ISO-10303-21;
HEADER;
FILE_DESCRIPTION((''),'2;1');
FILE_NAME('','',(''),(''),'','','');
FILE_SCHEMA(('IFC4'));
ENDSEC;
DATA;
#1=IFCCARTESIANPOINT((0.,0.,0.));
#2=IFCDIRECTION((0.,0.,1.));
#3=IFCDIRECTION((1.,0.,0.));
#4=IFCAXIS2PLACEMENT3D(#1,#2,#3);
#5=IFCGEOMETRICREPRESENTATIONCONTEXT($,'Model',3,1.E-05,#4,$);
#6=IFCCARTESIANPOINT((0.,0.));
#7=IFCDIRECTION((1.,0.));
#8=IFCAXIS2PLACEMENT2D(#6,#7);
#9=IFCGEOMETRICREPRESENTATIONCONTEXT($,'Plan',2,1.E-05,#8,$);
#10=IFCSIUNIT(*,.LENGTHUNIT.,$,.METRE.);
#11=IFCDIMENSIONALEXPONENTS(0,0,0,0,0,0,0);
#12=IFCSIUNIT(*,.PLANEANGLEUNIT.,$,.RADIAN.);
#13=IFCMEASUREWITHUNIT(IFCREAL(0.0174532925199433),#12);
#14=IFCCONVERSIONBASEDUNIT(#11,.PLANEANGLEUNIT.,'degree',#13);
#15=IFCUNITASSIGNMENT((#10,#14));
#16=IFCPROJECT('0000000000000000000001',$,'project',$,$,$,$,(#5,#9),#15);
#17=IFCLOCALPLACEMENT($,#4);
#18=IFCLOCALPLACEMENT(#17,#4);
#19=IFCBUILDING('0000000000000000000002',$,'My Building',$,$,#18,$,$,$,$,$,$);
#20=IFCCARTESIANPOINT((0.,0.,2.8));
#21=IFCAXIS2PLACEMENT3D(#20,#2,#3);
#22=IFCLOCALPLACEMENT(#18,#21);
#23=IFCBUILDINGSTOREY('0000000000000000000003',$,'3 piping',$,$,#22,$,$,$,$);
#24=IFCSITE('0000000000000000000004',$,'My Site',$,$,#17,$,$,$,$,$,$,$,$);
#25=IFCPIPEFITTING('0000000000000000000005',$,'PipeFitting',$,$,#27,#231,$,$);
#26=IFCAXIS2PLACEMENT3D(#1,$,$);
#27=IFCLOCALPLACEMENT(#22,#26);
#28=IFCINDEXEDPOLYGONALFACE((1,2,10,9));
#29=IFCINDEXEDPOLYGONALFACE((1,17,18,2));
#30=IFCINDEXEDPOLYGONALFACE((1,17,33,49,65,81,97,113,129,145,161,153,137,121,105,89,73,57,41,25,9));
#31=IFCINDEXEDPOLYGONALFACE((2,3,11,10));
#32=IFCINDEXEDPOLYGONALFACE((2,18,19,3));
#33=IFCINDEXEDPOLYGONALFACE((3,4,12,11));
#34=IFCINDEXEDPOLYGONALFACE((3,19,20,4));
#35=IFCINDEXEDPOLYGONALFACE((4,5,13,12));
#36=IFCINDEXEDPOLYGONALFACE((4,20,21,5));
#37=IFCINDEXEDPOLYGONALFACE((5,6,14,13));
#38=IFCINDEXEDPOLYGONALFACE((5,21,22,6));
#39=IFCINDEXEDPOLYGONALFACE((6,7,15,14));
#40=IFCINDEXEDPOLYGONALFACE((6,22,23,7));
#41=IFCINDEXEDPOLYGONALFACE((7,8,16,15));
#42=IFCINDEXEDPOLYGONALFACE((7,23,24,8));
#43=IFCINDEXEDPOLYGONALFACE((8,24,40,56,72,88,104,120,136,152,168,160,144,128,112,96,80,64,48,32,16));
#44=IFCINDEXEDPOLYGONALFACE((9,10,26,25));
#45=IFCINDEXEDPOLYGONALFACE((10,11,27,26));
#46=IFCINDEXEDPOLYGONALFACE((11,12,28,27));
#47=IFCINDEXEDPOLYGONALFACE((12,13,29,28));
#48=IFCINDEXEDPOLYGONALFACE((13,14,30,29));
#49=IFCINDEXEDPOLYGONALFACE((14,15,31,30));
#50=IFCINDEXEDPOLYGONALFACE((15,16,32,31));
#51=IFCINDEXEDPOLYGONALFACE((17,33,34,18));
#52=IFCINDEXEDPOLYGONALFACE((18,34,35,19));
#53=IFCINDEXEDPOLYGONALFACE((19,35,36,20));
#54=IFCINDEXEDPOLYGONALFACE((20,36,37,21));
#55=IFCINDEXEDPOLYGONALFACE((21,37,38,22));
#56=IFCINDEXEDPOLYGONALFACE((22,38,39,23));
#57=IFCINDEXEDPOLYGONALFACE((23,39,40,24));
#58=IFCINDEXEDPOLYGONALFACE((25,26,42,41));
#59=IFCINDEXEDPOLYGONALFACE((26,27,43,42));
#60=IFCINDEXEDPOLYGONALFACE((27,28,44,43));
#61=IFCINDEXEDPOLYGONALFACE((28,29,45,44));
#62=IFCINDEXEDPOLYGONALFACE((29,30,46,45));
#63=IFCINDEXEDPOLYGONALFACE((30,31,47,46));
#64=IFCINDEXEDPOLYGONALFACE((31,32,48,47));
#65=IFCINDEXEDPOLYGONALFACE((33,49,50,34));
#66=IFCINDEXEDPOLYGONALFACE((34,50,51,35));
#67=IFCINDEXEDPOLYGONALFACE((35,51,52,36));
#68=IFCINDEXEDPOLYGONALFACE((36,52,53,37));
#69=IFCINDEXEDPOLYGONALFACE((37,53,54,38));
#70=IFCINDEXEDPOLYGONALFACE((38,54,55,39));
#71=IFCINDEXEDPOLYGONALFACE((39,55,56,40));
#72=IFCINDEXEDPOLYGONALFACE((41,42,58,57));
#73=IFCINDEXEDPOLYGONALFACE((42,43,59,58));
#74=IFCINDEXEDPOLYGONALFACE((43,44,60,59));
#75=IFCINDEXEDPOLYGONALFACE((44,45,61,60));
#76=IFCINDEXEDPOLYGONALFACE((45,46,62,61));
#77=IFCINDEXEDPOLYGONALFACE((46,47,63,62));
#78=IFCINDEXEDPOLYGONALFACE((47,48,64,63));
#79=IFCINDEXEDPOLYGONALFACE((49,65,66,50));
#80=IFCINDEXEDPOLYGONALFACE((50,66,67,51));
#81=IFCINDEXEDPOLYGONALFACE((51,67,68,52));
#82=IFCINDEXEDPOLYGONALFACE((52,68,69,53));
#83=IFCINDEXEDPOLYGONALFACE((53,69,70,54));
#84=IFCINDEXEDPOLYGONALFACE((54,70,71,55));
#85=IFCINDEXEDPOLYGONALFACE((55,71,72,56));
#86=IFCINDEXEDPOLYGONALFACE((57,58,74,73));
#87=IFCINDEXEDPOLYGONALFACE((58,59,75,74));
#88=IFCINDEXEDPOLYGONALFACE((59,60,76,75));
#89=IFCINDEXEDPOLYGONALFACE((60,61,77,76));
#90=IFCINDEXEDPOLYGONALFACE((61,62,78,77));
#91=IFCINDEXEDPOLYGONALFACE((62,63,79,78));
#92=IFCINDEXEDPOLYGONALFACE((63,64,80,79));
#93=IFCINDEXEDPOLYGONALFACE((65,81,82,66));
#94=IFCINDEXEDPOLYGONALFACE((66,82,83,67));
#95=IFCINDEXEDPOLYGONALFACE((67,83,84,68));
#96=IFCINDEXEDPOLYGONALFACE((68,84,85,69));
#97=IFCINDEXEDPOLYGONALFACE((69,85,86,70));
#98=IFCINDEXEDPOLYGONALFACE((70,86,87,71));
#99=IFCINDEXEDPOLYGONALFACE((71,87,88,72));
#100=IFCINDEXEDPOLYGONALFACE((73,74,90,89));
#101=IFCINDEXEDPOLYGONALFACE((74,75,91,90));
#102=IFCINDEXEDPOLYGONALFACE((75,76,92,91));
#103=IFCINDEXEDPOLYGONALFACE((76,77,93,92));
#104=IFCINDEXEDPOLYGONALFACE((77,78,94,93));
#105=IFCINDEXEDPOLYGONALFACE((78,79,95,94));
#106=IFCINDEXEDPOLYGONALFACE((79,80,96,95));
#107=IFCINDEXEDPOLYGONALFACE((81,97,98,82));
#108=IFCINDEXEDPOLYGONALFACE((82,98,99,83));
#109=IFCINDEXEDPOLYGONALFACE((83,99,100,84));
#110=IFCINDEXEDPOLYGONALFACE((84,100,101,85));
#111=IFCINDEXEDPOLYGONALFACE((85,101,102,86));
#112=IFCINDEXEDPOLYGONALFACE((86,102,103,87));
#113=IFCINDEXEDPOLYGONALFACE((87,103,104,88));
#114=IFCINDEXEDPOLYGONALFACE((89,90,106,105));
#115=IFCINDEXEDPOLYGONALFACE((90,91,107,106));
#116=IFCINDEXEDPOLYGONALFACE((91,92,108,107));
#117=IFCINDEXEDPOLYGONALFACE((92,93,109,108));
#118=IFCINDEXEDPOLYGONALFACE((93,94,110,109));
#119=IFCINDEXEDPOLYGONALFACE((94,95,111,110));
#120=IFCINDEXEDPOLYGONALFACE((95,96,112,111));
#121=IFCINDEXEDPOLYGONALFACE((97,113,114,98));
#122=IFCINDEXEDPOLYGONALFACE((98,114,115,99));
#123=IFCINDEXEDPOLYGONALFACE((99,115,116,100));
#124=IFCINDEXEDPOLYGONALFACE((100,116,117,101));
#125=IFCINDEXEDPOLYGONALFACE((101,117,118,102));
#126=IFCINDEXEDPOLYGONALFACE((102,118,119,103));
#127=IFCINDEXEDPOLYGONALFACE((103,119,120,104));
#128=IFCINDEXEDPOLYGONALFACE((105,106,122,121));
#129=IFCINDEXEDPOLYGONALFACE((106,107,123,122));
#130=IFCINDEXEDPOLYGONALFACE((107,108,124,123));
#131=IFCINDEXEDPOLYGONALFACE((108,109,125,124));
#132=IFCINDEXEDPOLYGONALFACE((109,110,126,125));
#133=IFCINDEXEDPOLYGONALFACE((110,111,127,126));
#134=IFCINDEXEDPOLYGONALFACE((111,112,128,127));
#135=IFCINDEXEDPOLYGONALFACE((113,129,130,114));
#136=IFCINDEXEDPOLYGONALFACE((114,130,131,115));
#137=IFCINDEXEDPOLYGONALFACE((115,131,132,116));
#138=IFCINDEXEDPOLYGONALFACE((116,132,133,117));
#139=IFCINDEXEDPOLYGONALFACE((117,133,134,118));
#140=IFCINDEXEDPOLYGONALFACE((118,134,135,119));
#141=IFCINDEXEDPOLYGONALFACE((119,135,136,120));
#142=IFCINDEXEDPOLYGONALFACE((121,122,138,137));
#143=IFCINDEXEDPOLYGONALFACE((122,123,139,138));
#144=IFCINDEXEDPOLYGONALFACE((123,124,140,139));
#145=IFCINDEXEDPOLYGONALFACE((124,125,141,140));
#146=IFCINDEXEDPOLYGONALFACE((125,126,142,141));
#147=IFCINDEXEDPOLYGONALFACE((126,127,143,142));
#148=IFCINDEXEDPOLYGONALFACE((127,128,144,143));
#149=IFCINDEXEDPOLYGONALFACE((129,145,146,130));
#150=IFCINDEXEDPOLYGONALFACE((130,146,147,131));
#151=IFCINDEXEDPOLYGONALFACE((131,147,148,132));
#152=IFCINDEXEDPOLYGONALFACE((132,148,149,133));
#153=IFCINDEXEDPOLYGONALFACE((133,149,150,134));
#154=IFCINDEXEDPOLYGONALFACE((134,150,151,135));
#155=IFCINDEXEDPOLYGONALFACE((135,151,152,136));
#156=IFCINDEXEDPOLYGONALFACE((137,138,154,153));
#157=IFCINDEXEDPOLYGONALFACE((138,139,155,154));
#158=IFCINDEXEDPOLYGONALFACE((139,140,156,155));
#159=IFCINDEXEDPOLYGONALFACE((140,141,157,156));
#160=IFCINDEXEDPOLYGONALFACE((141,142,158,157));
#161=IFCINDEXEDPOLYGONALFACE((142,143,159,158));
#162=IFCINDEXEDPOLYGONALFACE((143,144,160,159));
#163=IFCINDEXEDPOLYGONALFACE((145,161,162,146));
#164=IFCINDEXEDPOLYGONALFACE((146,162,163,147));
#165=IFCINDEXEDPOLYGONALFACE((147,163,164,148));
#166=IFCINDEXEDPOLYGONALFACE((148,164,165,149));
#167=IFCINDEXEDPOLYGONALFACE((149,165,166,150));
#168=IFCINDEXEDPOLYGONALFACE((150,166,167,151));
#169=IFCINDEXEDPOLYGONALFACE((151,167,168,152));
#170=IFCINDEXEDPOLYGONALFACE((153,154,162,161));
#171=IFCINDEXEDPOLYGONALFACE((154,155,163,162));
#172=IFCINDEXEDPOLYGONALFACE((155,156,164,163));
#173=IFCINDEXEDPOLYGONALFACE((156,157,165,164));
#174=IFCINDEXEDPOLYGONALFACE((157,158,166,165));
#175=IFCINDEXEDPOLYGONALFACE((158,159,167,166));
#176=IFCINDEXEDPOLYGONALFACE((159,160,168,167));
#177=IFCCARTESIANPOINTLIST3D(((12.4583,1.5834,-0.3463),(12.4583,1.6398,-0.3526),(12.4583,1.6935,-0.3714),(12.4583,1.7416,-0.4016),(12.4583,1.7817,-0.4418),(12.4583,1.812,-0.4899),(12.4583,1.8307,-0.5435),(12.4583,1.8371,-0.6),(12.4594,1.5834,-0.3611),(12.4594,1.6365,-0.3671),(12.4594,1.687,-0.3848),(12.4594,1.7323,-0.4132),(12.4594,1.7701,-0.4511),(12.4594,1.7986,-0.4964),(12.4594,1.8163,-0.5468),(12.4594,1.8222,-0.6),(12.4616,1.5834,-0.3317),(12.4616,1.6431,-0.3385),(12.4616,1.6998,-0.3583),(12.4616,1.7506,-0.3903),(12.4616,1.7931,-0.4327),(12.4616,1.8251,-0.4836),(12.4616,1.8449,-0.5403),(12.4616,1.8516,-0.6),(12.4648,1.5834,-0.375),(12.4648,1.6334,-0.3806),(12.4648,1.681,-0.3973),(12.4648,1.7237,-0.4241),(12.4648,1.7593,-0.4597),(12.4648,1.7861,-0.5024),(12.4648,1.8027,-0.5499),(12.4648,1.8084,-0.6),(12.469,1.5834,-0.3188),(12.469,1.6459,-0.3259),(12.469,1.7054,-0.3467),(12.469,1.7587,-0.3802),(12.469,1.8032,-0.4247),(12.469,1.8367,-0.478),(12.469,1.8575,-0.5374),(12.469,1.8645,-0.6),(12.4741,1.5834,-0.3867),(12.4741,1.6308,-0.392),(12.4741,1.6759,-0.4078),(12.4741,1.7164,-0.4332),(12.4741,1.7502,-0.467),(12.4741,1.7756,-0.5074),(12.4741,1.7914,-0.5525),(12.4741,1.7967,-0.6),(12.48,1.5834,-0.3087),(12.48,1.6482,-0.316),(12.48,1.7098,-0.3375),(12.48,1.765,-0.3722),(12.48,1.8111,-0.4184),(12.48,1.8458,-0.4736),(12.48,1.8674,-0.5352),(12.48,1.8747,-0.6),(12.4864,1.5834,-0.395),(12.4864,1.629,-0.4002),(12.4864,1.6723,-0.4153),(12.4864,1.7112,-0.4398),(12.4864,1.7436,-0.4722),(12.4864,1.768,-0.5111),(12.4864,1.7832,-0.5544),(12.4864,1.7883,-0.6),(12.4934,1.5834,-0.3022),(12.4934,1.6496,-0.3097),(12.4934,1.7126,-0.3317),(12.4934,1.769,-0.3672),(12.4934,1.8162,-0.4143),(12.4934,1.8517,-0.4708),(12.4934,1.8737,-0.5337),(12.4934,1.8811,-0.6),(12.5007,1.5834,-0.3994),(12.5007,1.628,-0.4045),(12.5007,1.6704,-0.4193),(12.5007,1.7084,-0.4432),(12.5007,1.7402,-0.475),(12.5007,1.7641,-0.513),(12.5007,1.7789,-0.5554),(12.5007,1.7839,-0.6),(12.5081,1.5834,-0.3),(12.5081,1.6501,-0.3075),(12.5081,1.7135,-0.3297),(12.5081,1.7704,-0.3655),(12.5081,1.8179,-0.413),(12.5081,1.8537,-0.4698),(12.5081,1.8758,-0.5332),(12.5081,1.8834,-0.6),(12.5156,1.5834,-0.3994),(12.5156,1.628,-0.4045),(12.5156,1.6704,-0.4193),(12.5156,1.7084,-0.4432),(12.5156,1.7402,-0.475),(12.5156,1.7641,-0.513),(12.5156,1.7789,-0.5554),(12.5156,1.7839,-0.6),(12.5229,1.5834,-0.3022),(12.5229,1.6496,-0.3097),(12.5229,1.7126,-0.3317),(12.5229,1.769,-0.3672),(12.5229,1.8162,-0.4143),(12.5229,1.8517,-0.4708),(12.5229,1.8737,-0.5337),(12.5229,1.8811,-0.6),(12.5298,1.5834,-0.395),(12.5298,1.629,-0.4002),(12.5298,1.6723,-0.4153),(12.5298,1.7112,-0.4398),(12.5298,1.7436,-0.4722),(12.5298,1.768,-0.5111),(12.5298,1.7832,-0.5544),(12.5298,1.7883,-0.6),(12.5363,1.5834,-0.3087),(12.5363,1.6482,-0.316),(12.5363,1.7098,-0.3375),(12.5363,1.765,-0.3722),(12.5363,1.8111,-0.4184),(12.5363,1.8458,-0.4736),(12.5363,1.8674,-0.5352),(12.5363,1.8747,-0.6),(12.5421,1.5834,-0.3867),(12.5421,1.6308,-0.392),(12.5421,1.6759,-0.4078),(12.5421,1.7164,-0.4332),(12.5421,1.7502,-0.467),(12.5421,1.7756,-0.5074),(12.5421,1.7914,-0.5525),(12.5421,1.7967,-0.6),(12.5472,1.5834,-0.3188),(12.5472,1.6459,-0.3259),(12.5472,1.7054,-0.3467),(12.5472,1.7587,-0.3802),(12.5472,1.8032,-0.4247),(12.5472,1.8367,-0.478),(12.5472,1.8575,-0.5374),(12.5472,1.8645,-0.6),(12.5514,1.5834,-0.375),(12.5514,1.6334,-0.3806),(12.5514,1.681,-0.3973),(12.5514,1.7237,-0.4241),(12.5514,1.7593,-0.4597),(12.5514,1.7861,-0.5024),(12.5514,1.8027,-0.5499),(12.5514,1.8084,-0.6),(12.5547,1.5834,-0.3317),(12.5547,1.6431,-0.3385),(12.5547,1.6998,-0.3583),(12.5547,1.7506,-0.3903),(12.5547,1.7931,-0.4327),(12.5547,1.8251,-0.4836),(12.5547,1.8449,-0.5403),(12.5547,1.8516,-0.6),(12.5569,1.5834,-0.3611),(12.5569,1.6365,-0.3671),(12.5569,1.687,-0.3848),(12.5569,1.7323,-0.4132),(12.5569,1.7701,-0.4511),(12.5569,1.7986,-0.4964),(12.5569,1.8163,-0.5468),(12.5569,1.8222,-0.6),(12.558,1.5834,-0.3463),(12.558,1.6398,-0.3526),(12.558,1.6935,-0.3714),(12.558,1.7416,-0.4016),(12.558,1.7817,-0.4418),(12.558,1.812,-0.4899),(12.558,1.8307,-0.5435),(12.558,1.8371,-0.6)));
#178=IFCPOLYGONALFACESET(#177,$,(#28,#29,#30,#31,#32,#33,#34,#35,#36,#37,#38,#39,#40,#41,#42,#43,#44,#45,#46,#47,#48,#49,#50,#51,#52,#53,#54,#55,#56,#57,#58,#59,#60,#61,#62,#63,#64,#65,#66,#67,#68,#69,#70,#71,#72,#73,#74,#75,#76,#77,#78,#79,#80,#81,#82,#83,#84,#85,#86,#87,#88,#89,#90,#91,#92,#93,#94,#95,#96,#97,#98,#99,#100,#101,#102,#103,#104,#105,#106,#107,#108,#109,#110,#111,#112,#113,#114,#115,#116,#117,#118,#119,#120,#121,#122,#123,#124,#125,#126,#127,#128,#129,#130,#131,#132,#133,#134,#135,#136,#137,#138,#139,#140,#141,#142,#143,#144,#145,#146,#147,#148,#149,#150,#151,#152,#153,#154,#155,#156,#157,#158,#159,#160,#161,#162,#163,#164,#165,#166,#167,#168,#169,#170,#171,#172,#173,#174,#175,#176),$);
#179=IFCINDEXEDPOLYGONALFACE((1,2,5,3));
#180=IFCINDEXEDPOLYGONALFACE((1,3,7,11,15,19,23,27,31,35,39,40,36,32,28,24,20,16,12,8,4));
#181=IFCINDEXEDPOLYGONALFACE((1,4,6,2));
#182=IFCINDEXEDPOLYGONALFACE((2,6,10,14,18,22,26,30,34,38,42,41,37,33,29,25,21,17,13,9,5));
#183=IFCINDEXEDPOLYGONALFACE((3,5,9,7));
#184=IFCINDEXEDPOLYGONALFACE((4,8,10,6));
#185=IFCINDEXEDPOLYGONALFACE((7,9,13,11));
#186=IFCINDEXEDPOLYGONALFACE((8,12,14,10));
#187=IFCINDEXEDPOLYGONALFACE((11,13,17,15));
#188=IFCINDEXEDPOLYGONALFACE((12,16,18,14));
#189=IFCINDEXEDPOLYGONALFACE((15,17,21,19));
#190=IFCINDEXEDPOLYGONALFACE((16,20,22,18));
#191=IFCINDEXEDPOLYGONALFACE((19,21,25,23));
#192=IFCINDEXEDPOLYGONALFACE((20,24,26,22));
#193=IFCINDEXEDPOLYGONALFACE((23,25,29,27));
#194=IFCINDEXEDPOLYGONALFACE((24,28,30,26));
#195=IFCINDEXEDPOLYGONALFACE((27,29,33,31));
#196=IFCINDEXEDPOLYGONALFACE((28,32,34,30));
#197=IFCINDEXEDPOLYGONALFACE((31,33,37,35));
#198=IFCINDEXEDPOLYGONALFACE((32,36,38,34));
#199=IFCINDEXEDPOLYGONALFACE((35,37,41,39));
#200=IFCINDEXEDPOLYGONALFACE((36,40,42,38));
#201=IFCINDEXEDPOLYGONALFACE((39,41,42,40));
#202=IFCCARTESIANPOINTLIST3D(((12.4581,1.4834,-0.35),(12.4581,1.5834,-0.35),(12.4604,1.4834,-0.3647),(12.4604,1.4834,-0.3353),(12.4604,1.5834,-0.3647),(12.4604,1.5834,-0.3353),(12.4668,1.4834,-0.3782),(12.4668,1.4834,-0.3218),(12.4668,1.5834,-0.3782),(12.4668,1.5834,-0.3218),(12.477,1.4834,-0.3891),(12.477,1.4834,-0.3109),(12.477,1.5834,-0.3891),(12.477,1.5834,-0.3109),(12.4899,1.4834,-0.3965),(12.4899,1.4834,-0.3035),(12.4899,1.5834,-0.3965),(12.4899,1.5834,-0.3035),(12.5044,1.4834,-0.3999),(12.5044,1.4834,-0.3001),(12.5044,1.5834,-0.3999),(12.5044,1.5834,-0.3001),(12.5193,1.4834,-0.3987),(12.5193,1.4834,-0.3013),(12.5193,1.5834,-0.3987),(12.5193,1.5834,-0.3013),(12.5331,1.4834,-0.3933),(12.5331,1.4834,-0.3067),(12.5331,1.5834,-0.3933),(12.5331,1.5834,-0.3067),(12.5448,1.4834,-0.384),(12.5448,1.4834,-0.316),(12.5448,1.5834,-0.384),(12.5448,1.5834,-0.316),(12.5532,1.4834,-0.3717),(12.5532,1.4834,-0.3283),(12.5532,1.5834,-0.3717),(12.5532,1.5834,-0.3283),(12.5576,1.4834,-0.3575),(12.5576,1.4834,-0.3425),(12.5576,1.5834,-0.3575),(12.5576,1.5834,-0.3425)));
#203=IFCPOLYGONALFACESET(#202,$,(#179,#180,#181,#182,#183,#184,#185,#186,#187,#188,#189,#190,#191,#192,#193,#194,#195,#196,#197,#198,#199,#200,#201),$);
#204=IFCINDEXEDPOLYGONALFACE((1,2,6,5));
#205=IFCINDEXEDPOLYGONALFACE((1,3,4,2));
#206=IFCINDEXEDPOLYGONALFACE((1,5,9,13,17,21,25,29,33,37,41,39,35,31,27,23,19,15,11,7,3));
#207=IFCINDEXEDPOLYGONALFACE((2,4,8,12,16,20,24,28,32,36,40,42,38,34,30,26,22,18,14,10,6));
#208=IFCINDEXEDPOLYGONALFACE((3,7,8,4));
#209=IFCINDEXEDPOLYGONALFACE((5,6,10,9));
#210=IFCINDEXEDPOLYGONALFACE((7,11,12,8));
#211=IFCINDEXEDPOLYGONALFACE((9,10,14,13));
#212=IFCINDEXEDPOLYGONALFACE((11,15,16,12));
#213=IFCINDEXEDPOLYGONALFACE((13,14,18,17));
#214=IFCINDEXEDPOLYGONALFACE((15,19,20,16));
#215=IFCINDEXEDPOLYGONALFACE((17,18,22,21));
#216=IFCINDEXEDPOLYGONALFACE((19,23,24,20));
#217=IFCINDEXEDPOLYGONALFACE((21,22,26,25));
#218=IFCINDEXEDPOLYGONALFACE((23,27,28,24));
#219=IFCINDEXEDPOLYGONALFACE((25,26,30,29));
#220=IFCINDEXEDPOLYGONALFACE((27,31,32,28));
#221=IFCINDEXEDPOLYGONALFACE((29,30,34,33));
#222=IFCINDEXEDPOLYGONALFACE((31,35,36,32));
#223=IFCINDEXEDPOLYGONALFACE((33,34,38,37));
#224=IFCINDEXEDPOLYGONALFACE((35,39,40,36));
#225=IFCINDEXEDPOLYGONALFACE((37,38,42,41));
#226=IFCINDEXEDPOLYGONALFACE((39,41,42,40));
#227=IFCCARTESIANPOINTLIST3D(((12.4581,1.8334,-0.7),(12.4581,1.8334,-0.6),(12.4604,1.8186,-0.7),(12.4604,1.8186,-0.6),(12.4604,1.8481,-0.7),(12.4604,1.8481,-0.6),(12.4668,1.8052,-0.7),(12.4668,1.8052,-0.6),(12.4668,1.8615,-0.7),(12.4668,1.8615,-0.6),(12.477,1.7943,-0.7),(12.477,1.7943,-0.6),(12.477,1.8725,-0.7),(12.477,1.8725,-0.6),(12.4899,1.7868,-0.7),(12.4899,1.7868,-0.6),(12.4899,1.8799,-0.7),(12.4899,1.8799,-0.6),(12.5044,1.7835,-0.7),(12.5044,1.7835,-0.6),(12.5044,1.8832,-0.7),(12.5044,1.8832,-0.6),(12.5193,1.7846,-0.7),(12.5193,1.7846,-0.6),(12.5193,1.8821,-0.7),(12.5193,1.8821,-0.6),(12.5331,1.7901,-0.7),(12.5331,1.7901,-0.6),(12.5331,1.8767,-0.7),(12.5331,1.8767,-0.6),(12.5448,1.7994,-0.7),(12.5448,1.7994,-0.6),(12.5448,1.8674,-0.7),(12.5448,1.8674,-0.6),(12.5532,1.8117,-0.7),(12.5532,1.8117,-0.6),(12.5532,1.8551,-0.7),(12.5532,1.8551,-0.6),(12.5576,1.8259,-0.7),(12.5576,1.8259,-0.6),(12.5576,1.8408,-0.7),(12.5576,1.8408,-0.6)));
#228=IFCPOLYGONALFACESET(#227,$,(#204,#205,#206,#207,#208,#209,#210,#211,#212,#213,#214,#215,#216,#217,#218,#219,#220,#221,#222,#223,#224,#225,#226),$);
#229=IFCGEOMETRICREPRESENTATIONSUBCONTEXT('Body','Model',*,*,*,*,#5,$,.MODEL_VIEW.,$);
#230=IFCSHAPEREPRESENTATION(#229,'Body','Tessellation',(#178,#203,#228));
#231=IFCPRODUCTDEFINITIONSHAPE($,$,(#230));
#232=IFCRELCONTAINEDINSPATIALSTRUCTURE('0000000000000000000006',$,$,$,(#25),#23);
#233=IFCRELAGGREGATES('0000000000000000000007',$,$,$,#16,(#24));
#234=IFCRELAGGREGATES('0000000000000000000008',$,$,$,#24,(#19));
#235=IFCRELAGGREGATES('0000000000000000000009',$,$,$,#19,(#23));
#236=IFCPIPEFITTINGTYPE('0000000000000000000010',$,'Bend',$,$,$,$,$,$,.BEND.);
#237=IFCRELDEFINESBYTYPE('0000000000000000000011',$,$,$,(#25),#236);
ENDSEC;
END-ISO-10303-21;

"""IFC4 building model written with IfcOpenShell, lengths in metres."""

from ifc_helpers import new_model, entity, si_unit, converted_unit, frame, origin_with_axes, origin_2d_with_axis, place, context, subcontext, project, spatial, circle, extrude, source, transform, mapped, type_object, type_shapes, element, save


model = new_model("IFC4")

# Units and contexts
model_context = context("Model", 3, precision=1e-05, world=origin_with_axes())
plan_context = context("Plan", 2, precision=1e-05, world=origin_2d_with_axis())
body_context = subcontext(model_context, "Body", "Model", "MODEL_VIEW")
ifc_project = project(units=[si_unit("LENGTHUNIT", "METRE"), converted_unit("PLANEANGLEUNIT", "degree", entity("IfcReal", 0.0174532925199433), si_unit("PLANEANGLEUNIT", "RADIAN"), dimensions=[0, 0, 0, 0, 0, 0, 0])], contexts=[model_context, plan_context])

# Site, building, storey
site_placement = place(None, origin_with_axes())
site = spatial("IfcSite", under=ifc_project, at=site_placement, Name="My Site")
building_placement = place(site_placement, origin_with_axes())
building = spatial("IfcBuilding", under=site, at=building_placement, Name="My Building")
storey_placement = place(building_placement, frame((0.0, 0.0, 2.8), z_axis=(0.0, 0.0, 1.0), x_axis=(1.0, 0.0, 0.0)))
storey = spatial("IfcBuildingStorey", under=building, at=storey_placement, Name="3 piping")

# Pipe fitting
pipe_fitting_type_1 = type_object("IfcPipeFittingType", Name="Bend", PredefinedType="BEND")
shared_shape = source(origin_with_axes(), body_context, "Body", "SolidModel", [
    entity("IfcSweptDiskSolid", entity("IfcIndexedPolyCurve", entity("IfcCartesianPointList3D", [[0.0, 0.0, 0.1], [0.0, -0.0732, 0.2768], [0.0, -0.25, 0.35]]), [entity("IfcArcIndex", [1, 2, 3])]), 0.05),
    extrude(circle(Radius=0.05), origin_with_axes(), (0.0, 0.0, 1.0), 0.1),
    extrude(circle(Radius=0.05), frame((0.0, -0.25, 0.35), z_axis=(0.0, -1.0, 0.0), x_axis=(1.0, 0.0, 0.0)), (0.0, 0.0, 1.0), 0.1),
])
type_shapes(pipe_fitting_type_1, [shared_shape])
for number, where, z_axis, x_axis, name in (
    (1, (12.5081, 1.4834, -0.35), (0.0, 1.0, 0.0), (-1.0, 0.0, 0.0), "PipeFitting"),
):
    element("IfcPipeFitting", number, at=place(storey_placement, frame(where, z_axis=z_axis, x_axis=x_axis)), inside=storey, type_object=pipe_fitting_type_1, Name=name, context=body_context, shape_type="MappedRepresentation", body=[
        mapped(shared_shape, transform((0.0, 0.0, 0.0), x_axis=(1.0, 0.0, 0.0), y_axis=(0.0, 1.0, 0.0), z_axis=(0.0, 0.0, 1.0), scale=1.0)),
    ])

save(model, "model.ifc")
